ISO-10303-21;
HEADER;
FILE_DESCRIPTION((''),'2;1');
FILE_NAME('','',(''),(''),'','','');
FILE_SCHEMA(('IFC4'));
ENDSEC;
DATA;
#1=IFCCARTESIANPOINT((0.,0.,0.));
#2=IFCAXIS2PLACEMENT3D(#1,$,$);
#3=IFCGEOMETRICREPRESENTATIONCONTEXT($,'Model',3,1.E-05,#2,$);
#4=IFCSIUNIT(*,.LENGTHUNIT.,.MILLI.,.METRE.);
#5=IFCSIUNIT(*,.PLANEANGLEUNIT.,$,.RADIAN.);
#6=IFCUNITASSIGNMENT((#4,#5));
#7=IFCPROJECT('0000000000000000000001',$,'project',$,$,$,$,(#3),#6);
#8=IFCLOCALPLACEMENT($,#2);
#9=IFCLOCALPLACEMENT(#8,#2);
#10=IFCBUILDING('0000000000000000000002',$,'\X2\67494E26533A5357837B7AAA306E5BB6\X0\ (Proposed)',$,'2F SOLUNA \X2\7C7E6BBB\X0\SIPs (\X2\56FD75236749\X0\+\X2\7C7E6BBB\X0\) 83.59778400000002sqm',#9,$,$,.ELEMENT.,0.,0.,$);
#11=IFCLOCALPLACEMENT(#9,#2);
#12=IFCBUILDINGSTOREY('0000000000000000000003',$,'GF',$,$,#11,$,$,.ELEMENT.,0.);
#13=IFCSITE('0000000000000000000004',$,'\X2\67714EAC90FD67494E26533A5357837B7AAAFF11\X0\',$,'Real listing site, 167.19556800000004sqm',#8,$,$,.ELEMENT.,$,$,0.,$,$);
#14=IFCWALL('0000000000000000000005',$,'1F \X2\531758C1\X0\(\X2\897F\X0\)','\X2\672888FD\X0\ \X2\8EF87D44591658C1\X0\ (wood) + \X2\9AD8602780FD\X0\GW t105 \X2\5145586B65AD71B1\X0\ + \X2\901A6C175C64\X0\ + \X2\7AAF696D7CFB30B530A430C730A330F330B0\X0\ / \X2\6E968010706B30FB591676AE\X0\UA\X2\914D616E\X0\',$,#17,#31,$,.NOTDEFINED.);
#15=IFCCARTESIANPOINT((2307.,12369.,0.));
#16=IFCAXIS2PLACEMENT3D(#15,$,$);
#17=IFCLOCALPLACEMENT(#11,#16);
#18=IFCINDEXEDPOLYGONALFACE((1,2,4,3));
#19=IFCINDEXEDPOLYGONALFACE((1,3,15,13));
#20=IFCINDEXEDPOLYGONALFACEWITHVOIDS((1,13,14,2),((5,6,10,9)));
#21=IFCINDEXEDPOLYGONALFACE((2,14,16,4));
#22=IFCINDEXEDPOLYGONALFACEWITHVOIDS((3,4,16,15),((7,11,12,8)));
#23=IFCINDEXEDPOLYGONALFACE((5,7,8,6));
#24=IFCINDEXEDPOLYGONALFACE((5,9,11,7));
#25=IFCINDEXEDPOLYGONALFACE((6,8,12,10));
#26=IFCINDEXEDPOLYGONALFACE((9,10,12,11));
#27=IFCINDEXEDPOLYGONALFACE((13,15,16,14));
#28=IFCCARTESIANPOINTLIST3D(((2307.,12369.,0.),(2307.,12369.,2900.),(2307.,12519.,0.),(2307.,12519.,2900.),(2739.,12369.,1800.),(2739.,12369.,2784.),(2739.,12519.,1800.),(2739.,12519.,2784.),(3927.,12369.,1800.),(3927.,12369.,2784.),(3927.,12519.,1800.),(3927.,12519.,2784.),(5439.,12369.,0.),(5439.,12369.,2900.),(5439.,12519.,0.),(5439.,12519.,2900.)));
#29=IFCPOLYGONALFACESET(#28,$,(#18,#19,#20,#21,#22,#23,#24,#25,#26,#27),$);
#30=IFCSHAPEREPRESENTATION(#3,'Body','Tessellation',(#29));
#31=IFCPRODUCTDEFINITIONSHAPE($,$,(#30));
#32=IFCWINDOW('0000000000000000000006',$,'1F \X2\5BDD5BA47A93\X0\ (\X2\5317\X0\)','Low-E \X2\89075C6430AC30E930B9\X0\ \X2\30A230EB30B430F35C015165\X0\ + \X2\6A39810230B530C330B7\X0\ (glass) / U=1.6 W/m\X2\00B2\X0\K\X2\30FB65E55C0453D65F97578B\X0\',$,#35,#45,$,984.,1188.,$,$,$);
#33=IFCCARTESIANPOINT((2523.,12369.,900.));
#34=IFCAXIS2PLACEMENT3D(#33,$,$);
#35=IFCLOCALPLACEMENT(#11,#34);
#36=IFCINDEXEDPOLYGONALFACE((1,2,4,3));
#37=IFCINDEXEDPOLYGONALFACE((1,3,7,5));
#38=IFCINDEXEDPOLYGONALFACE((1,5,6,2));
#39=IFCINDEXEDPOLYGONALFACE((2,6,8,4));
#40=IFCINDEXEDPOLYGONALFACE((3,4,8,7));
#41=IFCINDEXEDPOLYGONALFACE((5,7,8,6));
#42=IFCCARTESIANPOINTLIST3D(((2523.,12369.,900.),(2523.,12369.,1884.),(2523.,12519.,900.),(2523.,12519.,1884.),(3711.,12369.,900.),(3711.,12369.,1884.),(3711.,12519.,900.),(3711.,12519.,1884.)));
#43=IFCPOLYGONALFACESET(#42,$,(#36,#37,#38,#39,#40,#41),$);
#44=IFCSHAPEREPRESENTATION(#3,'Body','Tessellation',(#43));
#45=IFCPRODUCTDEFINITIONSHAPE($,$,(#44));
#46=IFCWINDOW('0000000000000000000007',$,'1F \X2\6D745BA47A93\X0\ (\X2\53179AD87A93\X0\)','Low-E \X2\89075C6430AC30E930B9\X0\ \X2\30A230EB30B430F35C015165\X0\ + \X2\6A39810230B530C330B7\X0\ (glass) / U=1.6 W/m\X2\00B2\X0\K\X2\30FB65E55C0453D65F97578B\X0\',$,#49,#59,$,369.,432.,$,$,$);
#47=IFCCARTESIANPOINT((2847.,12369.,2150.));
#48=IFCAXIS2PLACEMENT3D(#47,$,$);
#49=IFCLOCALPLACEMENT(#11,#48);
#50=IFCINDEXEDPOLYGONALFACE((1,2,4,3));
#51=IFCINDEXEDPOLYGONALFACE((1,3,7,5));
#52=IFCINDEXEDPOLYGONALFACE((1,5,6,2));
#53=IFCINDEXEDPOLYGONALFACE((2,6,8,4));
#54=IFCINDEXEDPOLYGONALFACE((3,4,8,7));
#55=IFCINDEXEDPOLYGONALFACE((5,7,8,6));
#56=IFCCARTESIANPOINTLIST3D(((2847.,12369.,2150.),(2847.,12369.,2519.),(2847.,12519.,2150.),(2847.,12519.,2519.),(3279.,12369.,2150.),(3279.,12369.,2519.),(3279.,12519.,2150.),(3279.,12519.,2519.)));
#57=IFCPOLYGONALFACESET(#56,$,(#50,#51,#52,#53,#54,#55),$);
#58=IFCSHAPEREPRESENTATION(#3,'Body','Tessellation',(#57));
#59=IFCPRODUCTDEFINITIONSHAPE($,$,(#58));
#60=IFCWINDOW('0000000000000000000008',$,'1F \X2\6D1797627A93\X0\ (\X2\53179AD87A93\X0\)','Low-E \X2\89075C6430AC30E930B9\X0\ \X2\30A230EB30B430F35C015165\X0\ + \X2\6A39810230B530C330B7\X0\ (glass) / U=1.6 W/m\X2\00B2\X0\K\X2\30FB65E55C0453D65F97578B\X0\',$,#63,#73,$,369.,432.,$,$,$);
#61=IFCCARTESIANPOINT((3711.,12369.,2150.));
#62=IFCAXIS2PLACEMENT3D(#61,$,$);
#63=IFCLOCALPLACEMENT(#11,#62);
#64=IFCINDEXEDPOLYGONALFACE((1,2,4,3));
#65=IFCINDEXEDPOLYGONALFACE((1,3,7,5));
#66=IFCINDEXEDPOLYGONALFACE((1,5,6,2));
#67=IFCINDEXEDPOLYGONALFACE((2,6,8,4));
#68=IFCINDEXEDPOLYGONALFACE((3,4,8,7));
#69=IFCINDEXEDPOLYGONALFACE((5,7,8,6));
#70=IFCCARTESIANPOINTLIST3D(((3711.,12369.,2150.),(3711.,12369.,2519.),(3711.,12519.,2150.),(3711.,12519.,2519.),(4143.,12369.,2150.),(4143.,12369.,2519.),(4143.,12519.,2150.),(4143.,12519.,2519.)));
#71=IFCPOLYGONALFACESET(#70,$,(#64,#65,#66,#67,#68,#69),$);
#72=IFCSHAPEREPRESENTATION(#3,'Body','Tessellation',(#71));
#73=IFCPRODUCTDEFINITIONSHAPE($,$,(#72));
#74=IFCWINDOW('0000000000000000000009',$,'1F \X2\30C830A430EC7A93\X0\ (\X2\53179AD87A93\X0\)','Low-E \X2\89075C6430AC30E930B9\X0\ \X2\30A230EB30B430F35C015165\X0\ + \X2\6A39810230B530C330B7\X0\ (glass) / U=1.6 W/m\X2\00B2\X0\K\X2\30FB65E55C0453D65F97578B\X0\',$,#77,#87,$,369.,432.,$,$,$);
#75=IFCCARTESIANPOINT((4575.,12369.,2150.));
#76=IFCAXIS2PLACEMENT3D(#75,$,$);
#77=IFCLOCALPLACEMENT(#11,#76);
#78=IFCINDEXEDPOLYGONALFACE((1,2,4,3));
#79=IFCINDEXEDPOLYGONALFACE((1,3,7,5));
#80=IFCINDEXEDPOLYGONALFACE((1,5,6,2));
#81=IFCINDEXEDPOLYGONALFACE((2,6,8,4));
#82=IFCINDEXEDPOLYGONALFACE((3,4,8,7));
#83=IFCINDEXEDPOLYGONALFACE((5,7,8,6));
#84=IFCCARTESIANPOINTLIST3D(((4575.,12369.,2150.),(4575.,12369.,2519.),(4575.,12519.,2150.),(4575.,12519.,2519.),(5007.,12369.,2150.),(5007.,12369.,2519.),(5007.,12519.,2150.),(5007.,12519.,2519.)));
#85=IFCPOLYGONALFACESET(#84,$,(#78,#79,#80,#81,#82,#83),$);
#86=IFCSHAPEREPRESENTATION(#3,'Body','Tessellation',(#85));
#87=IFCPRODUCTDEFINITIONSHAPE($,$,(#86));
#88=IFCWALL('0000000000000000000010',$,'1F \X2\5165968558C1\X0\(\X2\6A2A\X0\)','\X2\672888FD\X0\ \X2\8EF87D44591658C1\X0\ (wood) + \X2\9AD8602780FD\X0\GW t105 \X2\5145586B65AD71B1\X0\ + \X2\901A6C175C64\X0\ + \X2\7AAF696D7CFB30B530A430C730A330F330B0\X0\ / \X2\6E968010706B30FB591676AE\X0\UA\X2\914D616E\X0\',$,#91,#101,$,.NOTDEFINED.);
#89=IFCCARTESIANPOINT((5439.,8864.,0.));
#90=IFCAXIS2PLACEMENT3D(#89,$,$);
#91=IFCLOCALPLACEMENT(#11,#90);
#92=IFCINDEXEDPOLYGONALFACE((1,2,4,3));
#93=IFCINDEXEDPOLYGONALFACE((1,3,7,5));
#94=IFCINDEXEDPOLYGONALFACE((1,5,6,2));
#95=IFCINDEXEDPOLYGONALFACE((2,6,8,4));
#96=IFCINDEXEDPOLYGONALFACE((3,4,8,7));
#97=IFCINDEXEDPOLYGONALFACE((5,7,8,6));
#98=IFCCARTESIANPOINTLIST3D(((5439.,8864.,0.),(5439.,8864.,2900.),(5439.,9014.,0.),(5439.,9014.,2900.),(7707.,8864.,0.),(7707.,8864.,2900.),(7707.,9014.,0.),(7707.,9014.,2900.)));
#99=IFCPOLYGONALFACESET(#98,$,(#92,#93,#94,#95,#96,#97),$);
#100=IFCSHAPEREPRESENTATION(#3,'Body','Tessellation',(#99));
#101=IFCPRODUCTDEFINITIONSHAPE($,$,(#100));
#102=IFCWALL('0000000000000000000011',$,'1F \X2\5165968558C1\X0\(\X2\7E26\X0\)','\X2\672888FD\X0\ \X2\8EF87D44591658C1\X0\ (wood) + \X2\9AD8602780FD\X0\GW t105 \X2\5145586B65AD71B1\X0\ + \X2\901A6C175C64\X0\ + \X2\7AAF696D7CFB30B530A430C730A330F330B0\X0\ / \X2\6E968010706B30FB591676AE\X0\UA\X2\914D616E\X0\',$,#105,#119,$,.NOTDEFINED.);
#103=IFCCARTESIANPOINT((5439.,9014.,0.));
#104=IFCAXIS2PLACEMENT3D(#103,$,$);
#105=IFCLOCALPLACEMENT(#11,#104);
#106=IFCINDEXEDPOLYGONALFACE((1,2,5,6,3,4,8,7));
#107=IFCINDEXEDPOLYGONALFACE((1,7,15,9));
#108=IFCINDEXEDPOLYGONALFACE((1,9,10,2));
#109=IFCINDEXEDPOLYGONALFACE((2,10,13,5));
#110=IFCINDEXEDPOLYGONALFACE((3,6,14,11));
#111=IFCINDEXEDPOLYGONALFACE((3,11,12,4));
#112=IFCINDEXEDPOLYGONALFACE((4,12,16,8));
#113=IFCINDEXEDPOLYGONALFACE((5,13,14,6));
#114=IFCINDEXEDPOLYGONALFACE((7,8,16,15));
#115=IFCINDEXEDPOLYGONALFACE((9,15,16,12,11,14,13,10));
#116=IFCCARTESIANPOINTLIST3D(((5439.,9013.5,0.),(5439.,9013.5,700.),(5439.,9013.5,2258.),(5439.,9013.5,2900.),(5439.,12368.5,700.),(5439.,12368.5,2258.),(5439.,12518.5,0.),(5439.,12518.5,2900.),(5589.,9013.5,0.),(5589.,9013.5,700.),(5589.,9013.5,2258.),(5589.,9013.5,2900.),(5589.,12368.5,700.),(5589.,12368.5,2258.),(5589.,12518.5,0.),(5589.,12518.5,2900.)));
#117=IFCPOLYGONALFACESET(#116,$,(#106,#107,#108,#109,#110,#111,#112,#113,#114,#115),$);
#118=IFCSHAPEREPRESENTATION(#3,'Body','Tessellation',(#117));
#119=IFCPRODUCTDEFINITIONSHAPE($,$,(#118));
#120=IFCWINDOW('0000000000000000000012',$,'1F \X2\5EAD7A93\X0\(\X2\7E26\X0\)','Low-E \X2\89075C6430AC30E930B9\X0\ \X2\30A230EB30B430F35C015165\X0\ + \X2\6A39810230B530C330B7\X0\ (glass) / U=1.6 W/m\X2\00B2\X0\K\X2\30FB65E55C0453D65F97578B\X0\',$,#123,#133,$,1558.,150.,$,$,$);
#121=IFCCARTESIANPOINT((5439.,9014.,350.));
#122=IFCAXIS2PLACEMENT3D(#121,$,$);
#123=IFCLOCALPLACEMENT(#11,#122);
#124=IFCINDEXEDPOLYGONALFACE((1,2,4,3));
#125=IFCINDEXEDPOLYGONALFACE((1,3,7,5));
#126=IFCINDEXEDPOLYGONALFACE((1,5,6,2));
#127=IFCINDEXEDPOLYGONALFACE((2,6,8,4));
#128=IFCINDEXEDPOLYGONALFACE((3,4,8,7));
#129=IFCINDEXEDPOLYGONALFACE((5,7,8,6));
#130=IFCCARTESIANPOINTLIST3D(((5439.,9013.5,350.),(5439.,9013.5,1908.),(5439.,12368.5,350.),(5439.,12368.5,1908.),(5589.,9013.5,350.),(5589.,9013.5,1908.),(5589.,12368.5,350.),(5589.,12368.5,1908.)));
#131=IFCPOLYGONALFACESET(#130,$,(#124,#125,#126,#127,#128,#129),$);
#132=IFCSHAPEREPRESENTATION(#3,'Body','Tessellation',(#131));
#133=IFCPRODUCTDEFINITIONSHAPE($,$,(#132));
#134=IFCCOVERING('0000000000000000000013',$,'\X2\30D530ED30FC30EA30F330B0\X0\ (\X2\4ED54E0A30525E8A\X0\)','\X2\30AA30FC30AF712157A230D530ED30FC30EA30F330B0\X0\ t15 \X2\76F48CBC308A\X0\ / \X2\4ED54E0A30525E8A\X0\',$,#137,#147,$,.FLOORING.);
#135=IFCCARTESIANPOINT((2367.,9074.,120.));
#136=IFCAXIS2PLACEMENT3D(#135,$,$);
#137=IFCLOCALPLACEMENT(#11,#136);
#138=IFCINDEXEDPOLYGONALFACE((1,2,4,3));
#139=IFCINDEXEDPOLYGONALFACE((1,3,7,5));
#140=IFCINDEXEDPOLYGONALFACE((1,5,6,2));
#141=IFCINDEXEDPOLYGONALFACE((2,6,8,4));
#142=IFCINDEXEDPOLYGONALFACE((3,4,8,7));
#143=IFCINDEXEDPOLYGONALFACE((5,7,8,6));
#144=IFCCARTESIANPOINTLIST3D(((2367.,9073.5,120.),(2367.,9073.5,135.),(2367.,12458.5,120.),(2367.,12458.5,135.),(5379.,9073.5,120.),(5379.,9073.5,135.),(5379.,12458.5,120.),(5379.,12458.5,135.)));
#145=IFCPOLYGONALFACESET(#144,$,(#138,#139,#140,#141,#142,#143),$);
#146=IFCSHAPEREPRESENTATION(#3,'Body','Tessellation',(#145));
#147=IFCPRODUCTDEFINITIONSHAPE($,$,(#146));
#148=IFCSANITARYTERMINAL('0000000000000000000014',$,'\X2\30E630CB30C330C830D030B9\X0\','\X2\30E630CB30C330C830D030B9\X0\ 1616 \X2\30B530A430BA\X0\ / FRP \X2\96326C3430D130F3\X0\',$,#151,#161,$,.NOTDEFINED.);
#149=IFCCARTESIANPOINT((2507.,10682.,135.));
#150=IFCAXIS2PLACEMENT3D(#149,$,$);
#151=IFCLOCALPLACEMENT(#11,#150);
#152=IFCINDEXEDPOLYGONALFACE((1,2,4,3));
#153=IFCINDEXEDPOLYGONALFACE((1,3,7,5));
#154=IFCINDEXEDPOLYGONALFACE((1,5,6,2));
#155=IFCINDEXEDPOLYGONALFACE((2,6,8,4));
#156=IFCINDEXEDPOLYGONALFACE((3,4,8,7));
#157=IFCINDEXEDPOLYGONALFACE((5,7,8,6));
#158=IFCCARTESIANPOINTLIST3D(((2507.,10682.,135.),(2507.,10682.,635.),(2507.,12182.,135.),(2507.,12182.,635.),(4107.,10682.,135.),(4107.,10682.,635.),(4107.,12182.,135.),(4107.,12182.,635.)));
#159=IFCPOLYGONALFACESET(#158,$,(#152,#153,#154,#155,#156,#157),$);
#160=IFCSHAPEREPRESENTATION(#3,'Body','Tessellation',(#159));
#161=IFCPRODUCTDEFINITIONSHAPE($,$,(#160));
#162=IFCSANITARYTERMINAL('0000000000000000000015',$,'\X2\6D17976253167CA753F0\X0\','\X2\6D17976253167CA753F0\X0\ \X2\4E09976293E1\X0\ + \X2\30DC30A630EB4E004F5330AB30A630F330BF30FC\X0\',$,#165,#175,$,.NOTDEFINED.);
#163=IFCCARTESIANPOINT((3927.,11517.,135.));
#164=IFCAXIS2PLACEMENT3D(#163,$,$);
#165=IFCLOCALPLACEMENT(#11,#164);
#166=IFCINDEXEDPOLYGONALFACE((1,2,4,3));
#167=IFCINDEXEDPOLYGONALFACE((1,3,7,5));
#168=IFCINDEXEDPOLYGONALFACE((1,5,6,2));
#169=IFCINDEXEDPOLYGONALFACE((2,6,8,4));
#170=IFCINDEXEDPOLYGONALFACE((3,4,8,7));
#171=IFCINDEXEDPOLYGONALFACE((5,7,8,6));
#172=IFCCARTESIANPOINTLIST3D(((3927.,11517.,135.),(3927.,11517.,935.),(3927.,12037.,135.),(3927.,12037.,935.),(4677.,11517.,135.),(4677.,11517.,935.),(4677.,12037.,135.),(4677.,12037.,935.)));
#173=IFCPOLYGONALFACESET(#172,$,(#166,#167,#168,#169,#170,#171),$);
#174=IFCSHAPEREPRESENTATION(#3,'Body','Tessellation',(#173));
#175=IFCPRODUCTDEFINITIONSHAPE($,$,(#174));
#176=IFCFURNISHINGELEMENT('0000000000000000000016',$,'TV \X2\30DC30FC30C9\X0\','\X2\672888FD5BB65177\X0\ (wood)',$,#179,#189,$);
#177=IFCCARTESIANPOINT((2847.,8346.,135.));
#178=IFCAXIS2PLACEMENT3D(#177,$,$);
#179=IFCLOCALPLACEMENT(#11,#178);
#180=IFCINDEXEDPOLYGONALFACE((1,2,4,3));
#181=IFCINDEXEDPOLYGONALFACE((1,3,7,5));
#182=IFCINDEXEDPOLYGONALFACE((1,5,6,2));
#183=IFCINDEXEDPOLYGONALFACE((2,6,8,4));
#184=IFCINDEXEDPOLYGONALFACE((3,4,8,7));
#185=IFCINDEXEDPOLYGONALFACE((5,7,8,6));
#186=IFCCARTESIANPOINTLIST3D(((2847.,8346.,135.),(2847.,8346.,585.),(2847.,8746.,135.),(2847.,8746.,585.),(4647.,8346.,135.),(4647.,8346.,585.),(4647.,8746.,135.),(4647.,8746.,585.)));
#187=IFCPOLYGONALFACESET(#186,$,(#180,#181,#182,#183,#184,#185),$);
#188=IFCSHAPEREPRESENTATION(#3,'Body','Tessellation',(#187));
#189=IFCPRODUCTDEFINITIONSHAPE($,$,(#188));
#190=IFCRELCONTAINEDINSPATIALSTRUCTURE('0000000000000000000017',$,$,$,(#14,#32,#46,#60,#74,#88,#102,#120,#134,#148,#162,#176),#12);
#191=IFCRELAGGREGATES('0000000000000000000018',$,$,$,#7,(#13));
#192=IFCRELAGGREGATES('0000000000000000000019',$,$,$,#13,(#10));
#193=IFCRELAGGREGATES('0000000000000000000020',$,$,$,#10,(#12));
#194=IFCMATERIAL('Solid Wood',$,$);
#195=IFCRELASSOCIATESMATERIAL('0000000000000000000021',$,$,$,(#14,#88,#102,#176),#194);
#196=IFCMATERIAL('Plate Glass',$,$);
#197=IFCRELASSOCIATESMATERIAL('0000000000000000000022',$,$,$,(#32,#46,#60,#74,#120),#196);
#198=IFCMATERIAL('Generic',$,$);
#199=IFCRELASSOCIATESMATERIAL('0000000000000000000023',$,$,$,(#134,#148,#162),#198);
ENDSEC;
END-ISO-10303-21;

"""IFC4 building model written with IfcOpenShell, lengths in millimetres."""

from ifc_helpers import new_model, si_unit, frame, frame_2d, origin, place, context, project, spatial, rectangle, extrude, material, element, fill, save


model = new_model("IFC4")

# Units and contexts
model_context = context("Model", 3, precision=1e-05, world=origin())
ifc_project = project(units=[si_unit("LENGTHUNIT", "METRE", prefix="MILLI"), si_unit("PLANEANGLEUNIT", "RADIAN")], contexts=[model_context])

# Site, building, storey
site_placement = place(None, origin())
site = spatial("IfcSite", under=ifc_project, at=site_placement, Name="東京都杉並区南荻窪１", ObjectType="Real listing site, 167.19556800000004sqm", CompositionType="ELEMENT", RefElevation=0.0)
building_placement = place(site_placement, origin())
building = spatial("IfcBuilding", under=site, at=building_placement, Name="杉並区南荻窪の家 (Proposed)", ObjectType="2F SOLUNA 籾殻SIPs (国産杉+籾殻) 83.59778400000002sqm", CompositionType="ELEMENT", ElevationOfRefHeight=0.0, ElevationOfTerrain=0.0)
storey_placement = place(building_placement, origin())
storey = spatial("IfcBuildingStorey", under=building, at=storey_placement, Name="GF", CompositionType="ELEMENT", Elevation=0.0)

# Shared definitions
ifc_material_1 = material(Name="Solid Wood")

# Wall, openings, windows
wall_1_placement = place(storey_placement, frame((2307.0, 12369.0, 0.0)))
wall_1 = element("IfcWall", 1, at=wall_1_placement, inside=storey, material=ifc_material_1, Name="1F 北壁(西)", Description="木製 軸組外壁 (wood) + 高性能GW t105 充填断熱 + 通気層 + 窯業系サイディング / 準耐火・外皮UA配慮", PredefinedType="NOTDEFINED", context=model_context, shape_type="SweptSolid", body=[
    extrude(rectangle(XDim=3132.0, YDim=150.0, at=frame_2d((1566.0, 75.0))), frame((2307.0, 12369.0, 0.0)), (0.0, 0.0, 1.0), 2900.0),
])
opening_1_placement = place(storey_placement, frame((2523.0, 12369.0, 900.0)))
opening_1 = element("IfcOpeningElement", 2, at=opening_1_placement, cuts=wall_1, PredefinedType="NOTDEFINED", context=model_context, shape_type="SweptSolid", body=[
    extrude(rectangle(XDim=1188.0, YDim=150.0, at=frame_2d((594.0, 75.0))), frame((2523.0, 12369.0, 900.0)), (0.0, 0.0, 1.0), 984.0),
])
opening_2_placement = place(storey_placement, frame((2847.0, 12369.0, 2150.0)))
opening_2 = element("IfcOpeningElement", 3, at=opening_2_placement, cuts=wall_1, PredefinedType="NOTDEFINED", context=model_context, shape_type="SweptSolid", body=[
    extrude(rectangle(XDim=432.0, YDim=150.0, at=frame_2d((216.0, 75.0))), frame((2847.0, 12369.0, 2150.0)), (0.0, 0.0, 1.0), 369.0),
])
opening_3_placement = place(storey_placement, frame((3711.0, 12369.0, 2150.0)))
opening_3 = element("IfcOpeningElement", 4, at=opening_3_placement, cuts=wall_1, PredefinedType="NOTDEFINED", context=model_context, shape_type="SweptSolid", body=[
    extrude(rectangle(XDim=432.0, YDim=150.0, at=frame_2d((216.0, 75.0))), frame((3711.0, 12369.0, 2150.0)), (0.0, 0.0, 1.0), 369.0),
])
opening_4_placement = place(storey_placement, frame((4575.0, 12369.0, 2150.0)))
opening_4 = element("IfcOpeningElement", 5, at=opening_4_placement, cuts=wall_1, PredefinedType="NOTDEFINED", context=model_context, shape_type="SweptSolid", body=[
    extrude(rectangle(XDim=432.0, YDim=150.0, at=frame_2d((216.0, 75.0))), frame((4575.0, 12369.0, 2150.0)), (0.0, 0.0, 1.0), 369.0),
])
ifc_material_2 = material(Name="Plate Glass")
window_1_placement = place(storey_placement, frame((2523.0, 12369.0, 900.0)))
window_1 = element("IfcWindow", 6, at=window_1_placement, inside=storey, material=ifc_material_2, Name="1F 寝室窓 (北)", Description="Low-E 複層ガラス アルゴン封入 + 樹脂サッシ (glass) / U=1.6 W/m²K・日射取得型", OverallHeight=984.0, OverallWidth=1188.0, context=model_context, shape_type="SweptSolid", body=[
    extrude(rectangle(XDim=1188.0, YDim=150.0, at=frame_2d((594.0, 75.0))), frame((2523.0, 12369.0, 900.0)), (0.0, 0.0, 1.0), 984.0),
])
fill(opening_1, window_1)
window_2_placement = place(storey_placement, frame((2847.0, 12369.0, 2150.0)))
window_2 = element("IfcWindow", 7, at=window_2_placement, inside=storey, material=ifc_material_2, Name="1F 浴室窓 (北高窓)", Description="Low-E 複層ガラス アルゴン封入 + 樹脂サッシ (glass) / U=1.6 W/m²K・日射取得型", OverallHeight=369.0, OverallWidth=432.0, context=model_context, shape_type="SweptSolid", body=[
    extrude(rectangle(XDim=432.0, YDim=150.0, at=frame_2d((216.0, 75.0))), frame((2847.0, 12369.0, 2150.0)), (0.0, 0.0, 1.0), 369.0),
])
fill(opening_2, window_2)
window_3_placement = place(storey_placement, frame((3711.0, 12369.0, 2150.0)))
window_3 = element("IfcWindow", 8, at=window_3_placement, inside=storey, material=ifc_material_2, Name="1F 洗面窓 (北高窓)", Description="Low-E 複層ガラス アルゴン封入 + 樹脂サッシ (glass) / U=1.6 W/m²K・日射取得型", OverallHeight=369.0, OverallWidth=432.0, context=model_context, shape_type="SweptSolid", body=[
    extrude(rectangle(XDim=432.0, YDim=150.0, at=frame_2d((216.0, 75.0))), frame((3711.0, 12369.0, 2150.0)), (0.0, 0.0, 1.0), 369.0),
])
fill(opening_3, window_3)
window_4_placement = place(storey_placement, frame((4575.0, 12369.0, 2150.0)))
window_4 = element("IfcWindow", 9, at=window_4_placement, inside=storey, material=ifc_material_2, Name="1F トイレ窓 (北高窓)", Description="Low-E 複層ガラス アルゴン封入 + 樹脂サッシ (glass) / U=1.6 W/m²K・日射取得型", OverallHeight=369.0, OverallWidth=432.0, context=model_context, shape_type="SweptSolid", body=[
    extrude(rectangle(XDim=432.0, YDim=150.0, at=frame_2d((216.0, 75.0))), frame((4575.0, 12369.0, 2150.0)), (0.0, 0.0, 1.0), 369.0),
])
fill(opening_4, window_4)

# Wall
wall_2_placement = place(storey_placement, frame((5439.0, 8864.0, 0.0)))
element("IfcWall", 10, at=wall_2_placement, inside=storey, material=ifc_material_1, Name="1F 入隅壁(横)", Description="木製 軸組外壁 (wood) + 高性能GW t105 充填断熱 + 通気層 + 窯業系サイディング / 準耐火・外皮UA配慮", PredefinedType="NOTDEFINED", context=model_context, shape_type="SweptSolid", body=[
    extrude(rectangle(XDim=2268.0, YDim=150.0, at=frame_2d((1134.0, 75.0))), frame((5439.0, 8864.0, 0.0)), (0.0, 0.0, 1.0), 2900.0),
])

# Wall, opening, window
wall_3_placement = place(storey_placement, frame((5439.0, 9014.0, 0.0)))
wall_3 = element("IfcWall", 11, at=wall_3_placement, inside=storey, material=ifc_material_1, Name="1F 入隅壁(縦)", Description="木製 軸組外壁 (wood) + 高性能GW t105 充填断熱 + 通気層 + 窯業系サイディング / 準耐火・外皮UA配慮", PredefinedType="NOTDEFINED", context=model_context, shape_type="SweptSolid", body=[
    extrude(rectangle(XDim=150.0, YDim=3505.0, at=frame_2d((75.0, 1752.0))), frame((5439.0, 9014.0, 0.0)), (0.0, 0.0, 1.0), 2900.0),
])
opening_5_placement = place(storey_placement, frame((5439.0, 9014.0, 350.0)))
opening_5 = element("IfcOpeningElement", 12, at=opening_5_placement, cuts=wall_3, PredefinedType="NOTDEFINED", context=model_context, shape_type="SweptSolid", body=[
    extrude(rectangle(XDim=150.0, YDim=3355.0, at=frame_2d((75.0, 1677.0))), frame((5439.0, 9014.0, 350.0)), (0.0, 0.0, 1.0), 1558.0),
])
window_5_placement = place(storey_placement, frame((5439.0, 9014.0, 350.0)))
window_5 = element("IfcWindow", 13, at=window_5_placement, inside=storey, material=ifc_material_2, Name="1F 庭窓(縦)", Description="Low-E 複層ガラス アルゴン封入 + 樹脂サッシ (glass) / U=1.6 W/m²K・日射取得型", OverallHeight=1558.0, OverallWidth=150.0, context=model_context, shape_type="SweptSolid", body=[
    extrude(rectangle(XDim=150.0, YDim=3355.0, at=frame_2d((75.0, 1677.0))), frame((5439.0, 9014.0, 350.0)), (0.0, 0.0, 1.0), 1558.0),
])
fill(opening_5, window_5)

# Covering
ifc_material_3 = material(Name="Generic")
covering_placement = place(storey_placement, frame((2367.0, 9074.0, 120.0)))
element("IfcCovering", 14, at=covering_placement, inside=storey, material=ifc_material_3, Name="フローリング (仕上げ床)", Description="オーク無垢フローリング t15 直貼り / 仕上げ床", PredefinedType="FLOORING", context=model_context, shape_type="SweptSolid", body=[
    extrude(rectangle(XDim=3012.0, YDim=3385.0, at=frame_2d((1506.0, 1692.0))), frame((2367.0, 9074.0, 120.0)), (0.0, 0.0, 1.0), 15.0),
])

# Sanitary terminals
sanitary_terminal_1_placement = place(storey_placement, frame((2507.0, 10682.0, 135.0)))
element("IfcSanitaryTerminal", 15, at=sanitary_terminal_1_placement, inside=storey, material=ifc_material_3, Name="ユニットバス", Description="ユニットバス 1616 サイズ / FRP 防水パン", PredefinedType="NOTDEFINED", context=model_context, shape_type="SweptSolid", body=[
    extrude(rectangle(XDim=1600.0, YDim=1500.0, at=frame_2d((800.0, 750.0))), frame((2507.0, 10682.0, 135.0)), (0.0, 0.0, 1.0), 500.0),
])
sanitary_terminal_2_placement = place(storey_placement, frame((3927.0, 11517.0, 135.0)))
element("IfcSanitaryTerminal", 16, at=sanitary_terminal_2_placement, inside=storey, material=ifc_material_3, Name="洗面化粧台", Description="洗面化粧台 三面鏡 + ボウル一体カウンター", PredefinedType="NOTDEFINED", context=model_context, shape_type="SweptSolid", body=[
    extrude(rectangle(XDim=750.0, YDim=520.0, at=frame_2d((375.0, 260.0))), frame((3927.0, 11517.0, 135.0)), (0.0, 0.0, 1.0), 800.0),
])

# Furnishing element
furnishing_placement = place(storey_placement, frame((2847.0, 8346.0, 135.0)))
element("IfcFurnishingElement", 17, at=furnishing_placement, inside=storey, material=ifc_material_1, Name="TV ボード", Description="木製家具 (wood)", context=model_context, shape_type="SweptSolid", body=[
    extrude(rectangle(XDim=1800.0, YDim=400.0, at=frame_2d((900.0, 200.0))), frame((2847.0, 8346.0, 135.0)), (0.0, 0.0, 1.0), 450.0),
])

save(model, "model.ifc")
